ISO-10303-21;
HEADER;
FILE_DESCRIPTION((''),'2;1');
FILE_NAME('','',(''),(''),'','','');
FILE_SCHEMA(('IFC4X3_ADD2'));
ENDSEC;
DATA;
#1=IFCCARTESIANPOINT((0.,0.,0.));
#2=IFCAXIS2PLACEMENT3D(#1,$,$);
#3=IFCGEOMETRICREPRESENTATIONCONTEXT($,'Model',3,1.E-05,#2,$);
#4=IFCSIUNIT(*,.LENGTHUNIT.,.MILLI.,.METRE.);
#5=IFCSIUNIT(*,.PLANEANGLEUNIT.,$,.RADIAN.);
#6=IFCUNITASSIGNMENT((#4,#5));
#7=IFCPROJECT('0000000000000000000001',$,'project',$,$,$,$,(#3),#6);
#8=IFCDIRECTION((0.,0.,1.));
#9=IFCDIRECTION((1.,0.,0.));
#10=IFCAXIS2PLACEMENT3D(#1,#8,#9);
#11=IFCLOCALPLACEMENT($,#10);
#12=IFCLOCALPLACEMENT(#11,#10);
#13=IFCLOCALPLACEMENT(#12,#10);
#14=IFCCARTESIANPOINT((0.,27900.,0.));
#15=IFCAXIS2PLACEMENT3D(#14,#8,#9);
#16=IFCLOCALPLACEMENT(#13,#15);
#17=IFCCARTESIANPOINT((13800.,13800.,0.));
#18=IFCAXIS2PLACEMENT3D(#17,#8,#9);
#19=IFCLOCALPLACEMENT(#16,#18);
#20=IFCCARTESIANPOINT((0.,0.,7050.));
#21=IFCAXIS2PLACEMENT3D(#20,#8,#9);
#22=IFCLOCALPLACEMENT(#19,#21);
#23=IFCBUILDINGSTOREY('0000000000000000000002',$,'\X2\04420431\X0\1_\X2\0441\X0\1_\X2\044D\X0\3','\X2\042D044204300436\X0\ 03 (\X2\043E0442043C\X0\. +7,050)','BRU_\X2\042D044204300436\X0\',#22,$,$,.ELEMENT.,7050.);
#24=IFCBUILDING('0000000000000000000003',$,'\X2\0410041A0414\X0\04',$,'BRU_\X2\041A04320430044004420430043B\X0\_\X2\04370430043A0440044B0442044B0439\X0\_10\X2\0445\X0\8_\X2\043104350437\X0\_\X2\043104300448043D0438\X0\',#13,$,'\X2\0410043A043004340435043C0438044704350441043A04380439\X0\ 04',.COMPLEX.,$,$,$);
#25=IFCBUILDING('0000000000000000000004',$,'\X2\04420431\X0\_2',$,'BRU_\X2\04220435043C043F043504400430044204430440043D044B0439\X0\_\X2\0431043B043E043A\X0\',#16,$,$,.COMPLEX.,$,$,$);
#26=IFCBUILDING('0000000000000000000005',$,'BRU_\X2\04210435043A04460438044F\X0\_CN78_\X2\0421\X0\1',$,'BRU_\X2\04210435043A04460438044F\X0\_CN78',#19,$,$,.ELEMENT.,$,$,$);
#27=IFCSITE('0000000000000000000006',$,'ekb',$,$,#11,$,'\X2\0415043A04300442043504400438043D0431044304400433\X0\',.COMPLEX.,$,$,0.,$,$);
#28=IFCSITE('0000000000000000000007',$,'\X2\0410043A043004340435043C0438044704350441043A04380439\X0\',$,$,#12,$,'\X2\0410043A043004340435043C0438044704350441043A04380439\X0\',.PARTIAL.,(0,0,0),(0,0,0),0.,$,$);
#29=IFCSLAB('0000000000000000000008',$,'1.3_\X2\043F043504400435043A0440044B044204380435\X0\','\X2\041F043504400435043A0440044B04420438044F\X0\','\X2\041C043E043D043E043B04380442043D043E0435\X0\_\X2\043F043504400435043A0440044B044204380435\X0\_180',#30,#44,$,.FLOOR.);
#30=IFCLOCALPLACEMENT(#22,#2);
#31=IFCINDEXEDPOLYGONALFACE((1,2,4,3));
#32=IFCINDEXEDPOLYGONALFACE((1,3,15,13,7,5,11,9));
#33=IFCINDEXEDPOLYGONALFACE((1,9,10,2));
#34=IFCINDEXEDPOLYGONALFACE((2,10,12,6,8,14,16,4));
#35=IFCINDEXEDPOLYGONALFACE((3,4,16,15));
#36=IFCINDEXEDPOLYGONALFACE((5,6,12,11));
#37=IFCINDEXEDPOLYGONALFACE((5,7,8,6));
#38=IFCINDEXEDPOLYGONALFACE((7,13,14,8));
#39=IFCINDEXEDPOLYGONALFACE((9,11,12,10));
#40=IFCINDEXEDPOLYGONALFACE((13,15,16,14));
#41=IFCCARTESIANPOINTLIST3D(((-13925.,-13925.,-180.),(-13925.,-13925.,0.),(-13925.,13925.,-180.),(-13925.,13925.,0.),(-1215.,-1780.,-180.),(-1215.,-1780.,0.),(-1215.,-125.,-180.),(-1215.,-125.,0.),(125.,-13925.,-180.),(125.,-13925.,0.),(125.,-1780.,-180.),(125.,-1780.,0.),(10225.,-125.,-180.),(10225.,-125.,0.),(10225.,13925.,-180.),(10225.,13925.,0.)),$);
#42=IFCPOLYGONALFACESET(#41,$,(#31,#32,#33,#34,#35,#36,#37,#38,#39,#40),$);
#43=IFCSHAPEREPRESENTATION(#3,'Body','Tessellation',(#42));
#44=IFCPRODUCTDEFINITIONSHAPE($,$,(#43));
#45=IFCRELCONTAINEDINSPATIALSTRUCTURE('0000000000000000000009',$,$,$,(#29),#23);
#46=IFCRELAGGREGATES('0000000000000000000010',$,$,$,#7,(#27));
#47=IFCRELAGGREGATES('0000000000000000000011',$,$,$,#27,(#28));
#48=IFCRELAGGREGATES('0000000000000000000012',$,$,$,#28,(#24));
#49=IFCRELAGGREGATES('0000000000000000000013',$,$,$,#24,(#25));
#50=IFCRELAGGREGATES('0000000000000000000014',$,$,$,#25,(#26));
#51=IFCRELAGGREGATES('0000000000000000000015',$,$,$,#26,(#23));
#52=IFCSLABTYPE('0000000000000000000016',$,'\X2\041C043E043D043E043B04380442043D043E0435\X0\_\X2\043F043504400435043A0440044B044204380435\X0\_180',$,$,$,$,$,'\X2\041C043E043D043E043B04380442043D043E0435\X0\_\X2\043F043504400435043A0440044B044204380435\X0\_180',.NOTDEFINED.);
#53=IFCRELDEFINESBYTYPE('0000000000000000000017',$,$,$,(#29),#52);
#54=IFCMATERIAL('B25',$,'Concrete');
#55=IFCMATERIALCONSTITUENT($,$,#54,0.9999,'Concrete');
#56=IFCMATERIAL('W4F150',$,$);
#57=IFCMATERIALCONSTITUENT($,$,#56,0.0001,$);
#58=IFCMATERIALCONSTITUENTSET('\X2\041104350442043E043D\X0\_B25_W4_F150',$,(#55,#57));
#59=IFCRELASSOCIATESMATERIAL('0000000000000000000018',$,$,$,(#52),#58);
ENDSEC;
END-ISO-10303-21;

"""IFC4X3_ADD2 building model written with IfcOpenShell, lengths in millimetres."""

from ifc_helpers import new_model, si_unit, frame, origin, origin_with_axes, place, context, project, spatial, polyline, outline, extrude, material, constituent, constituent_set, type_object, element, save


model = new_model("IFC4X3_ADD2")

# Units and contexts
model_context = context("Model", 3, precision=1e-05, world=origin())
ifc_project = project(units=[si_unit("LENGTHUNIT", "METRE", prefix="MILLI"), si_unit("PLANEANGLEUNIT", "RADIAN")], contexts=[model_context])

# Sites, buildings, storey
site_1_placement = place(None, origin_with_axes())
site_1 = spatial("IfcSite", under=ifc_project, at=site_1_placement, Name="ekb", LongName="Екатеринбург", CompositionType="COMPLEX", RefElevation=0.0)
site_2_placement = place(site_1_placement, origin_with_axes())
site_2 = spatial("IfcSite", under=site_1, at=site_2_placement, Name="Академический", LongName="Академический", CompositionType="PARTIAL", RefLatitude=(0, 0, 0), RefLongitude=(0, 0, 0), RefElevation=0.0)
building_1_placement = place(site_2_placement, origin_with_axes())
building_1 = spatial("IfcBuilding", under=site_2, at=building_1_placement, Name="АКД04", ObjectType="BRU_Квартал_закрытый_10х8_без_башни", LongName="Академический 04", CompositionType="COMPLEX")
building_2_placement = place(building_1_placement, frame((0.0, 27900.0, 0.0), z_axis=(0.0, 0.0, 1.0), x_axis=(1.0, 0.0, 0.0)))
building_2 = spatial("IfcBuilding", under=building_1, at=building_2_placement, Name="тб_2", ObjectType="BRU_Температурный_блок", CompositionType="COMPLEX")
building_3_placement = place(building_2_placement, frame((13800.0, 13800.0, 0.0), z_axis=(0.0, 0.0, 1.0), x_axis=(1.0, 0.0, 0.0)))
building_3 = spatial("IfcBuilding", under=building_2, at=building_3_placement, Name="BRU_Секция_CN78_С1", ObjectType="BRU_Секция_CN78", CompositionType="ELEMENT")
storey_placement = place(building_3_placement, frame((0.0, 0.0, 7050.0), z_axis=(0.0, 0.0, 1.0), x_axis=(1.0, 0.0, 0.0)))
storey = spatial("IfcBuildingStorey", under=building_3, at=storey_placement, Name="тб1_с1_э3", Description="Этаж 03 (отм. +7,050)", ObjectType="BRU_Этаж", CompositionType="ELEMENT", Elevation=7050.0)

# Shared definitions
ifc_material_1 = material(Name="B25", Category="Concrete")
ifc_material_2 = material(Name="W4F150")

# Slab
ifc_constituent_1 = constituent(ifc_material_1, Category="Concrete", fraction=0.9999)
ifc_constituent_2 = constituent(ifc_material_2, fraction=0.0001)
ifc_constituent_set_1 = constituent_set(constituents=[ifc_constituent_1, ifc_constituent_2], Name="Бетон_B25_W4_F150")
slab_type = type_object("IfcSlabType", Name="Монолитное_перекрытие_180", ElementType="Монолитное_перекрытие_180", PredefinedType="NOTDEFINED", material=ifc_constituent_set_1)
slab_placement = place(storey_placement, frame((0.0, 0.0, -180.0), z_axis=(0.0, 0.0, 1.0), x_axis=(1.0, 0.0, 0.0)))
element("IfcSlab", 1, at=slab_placement, inside=storey, type_object=slab_type, Name="1.3_перекрытие", Description="Перекрытия", ObjectType="Монолитное_перекрытие_180", PredefinedType="FLOOR", context=model_context, shape_type="SweptSolid", body=[
    extrude(outline(polyline([(-13925.0, -13925.0), (125.0, -13925.0), (125.0, -1780.0), (-1215.0, -1780.0), (-1215.0, -125.0), (10225.0, -125.0), (10225.0, 13925.0), (-13925.0, 13925.0), (-13925.0, -13925.0)])), origin_with_axes(), (0.0, 0.0, 1.0), 180.0),
])

save(model, "model.ifc")
